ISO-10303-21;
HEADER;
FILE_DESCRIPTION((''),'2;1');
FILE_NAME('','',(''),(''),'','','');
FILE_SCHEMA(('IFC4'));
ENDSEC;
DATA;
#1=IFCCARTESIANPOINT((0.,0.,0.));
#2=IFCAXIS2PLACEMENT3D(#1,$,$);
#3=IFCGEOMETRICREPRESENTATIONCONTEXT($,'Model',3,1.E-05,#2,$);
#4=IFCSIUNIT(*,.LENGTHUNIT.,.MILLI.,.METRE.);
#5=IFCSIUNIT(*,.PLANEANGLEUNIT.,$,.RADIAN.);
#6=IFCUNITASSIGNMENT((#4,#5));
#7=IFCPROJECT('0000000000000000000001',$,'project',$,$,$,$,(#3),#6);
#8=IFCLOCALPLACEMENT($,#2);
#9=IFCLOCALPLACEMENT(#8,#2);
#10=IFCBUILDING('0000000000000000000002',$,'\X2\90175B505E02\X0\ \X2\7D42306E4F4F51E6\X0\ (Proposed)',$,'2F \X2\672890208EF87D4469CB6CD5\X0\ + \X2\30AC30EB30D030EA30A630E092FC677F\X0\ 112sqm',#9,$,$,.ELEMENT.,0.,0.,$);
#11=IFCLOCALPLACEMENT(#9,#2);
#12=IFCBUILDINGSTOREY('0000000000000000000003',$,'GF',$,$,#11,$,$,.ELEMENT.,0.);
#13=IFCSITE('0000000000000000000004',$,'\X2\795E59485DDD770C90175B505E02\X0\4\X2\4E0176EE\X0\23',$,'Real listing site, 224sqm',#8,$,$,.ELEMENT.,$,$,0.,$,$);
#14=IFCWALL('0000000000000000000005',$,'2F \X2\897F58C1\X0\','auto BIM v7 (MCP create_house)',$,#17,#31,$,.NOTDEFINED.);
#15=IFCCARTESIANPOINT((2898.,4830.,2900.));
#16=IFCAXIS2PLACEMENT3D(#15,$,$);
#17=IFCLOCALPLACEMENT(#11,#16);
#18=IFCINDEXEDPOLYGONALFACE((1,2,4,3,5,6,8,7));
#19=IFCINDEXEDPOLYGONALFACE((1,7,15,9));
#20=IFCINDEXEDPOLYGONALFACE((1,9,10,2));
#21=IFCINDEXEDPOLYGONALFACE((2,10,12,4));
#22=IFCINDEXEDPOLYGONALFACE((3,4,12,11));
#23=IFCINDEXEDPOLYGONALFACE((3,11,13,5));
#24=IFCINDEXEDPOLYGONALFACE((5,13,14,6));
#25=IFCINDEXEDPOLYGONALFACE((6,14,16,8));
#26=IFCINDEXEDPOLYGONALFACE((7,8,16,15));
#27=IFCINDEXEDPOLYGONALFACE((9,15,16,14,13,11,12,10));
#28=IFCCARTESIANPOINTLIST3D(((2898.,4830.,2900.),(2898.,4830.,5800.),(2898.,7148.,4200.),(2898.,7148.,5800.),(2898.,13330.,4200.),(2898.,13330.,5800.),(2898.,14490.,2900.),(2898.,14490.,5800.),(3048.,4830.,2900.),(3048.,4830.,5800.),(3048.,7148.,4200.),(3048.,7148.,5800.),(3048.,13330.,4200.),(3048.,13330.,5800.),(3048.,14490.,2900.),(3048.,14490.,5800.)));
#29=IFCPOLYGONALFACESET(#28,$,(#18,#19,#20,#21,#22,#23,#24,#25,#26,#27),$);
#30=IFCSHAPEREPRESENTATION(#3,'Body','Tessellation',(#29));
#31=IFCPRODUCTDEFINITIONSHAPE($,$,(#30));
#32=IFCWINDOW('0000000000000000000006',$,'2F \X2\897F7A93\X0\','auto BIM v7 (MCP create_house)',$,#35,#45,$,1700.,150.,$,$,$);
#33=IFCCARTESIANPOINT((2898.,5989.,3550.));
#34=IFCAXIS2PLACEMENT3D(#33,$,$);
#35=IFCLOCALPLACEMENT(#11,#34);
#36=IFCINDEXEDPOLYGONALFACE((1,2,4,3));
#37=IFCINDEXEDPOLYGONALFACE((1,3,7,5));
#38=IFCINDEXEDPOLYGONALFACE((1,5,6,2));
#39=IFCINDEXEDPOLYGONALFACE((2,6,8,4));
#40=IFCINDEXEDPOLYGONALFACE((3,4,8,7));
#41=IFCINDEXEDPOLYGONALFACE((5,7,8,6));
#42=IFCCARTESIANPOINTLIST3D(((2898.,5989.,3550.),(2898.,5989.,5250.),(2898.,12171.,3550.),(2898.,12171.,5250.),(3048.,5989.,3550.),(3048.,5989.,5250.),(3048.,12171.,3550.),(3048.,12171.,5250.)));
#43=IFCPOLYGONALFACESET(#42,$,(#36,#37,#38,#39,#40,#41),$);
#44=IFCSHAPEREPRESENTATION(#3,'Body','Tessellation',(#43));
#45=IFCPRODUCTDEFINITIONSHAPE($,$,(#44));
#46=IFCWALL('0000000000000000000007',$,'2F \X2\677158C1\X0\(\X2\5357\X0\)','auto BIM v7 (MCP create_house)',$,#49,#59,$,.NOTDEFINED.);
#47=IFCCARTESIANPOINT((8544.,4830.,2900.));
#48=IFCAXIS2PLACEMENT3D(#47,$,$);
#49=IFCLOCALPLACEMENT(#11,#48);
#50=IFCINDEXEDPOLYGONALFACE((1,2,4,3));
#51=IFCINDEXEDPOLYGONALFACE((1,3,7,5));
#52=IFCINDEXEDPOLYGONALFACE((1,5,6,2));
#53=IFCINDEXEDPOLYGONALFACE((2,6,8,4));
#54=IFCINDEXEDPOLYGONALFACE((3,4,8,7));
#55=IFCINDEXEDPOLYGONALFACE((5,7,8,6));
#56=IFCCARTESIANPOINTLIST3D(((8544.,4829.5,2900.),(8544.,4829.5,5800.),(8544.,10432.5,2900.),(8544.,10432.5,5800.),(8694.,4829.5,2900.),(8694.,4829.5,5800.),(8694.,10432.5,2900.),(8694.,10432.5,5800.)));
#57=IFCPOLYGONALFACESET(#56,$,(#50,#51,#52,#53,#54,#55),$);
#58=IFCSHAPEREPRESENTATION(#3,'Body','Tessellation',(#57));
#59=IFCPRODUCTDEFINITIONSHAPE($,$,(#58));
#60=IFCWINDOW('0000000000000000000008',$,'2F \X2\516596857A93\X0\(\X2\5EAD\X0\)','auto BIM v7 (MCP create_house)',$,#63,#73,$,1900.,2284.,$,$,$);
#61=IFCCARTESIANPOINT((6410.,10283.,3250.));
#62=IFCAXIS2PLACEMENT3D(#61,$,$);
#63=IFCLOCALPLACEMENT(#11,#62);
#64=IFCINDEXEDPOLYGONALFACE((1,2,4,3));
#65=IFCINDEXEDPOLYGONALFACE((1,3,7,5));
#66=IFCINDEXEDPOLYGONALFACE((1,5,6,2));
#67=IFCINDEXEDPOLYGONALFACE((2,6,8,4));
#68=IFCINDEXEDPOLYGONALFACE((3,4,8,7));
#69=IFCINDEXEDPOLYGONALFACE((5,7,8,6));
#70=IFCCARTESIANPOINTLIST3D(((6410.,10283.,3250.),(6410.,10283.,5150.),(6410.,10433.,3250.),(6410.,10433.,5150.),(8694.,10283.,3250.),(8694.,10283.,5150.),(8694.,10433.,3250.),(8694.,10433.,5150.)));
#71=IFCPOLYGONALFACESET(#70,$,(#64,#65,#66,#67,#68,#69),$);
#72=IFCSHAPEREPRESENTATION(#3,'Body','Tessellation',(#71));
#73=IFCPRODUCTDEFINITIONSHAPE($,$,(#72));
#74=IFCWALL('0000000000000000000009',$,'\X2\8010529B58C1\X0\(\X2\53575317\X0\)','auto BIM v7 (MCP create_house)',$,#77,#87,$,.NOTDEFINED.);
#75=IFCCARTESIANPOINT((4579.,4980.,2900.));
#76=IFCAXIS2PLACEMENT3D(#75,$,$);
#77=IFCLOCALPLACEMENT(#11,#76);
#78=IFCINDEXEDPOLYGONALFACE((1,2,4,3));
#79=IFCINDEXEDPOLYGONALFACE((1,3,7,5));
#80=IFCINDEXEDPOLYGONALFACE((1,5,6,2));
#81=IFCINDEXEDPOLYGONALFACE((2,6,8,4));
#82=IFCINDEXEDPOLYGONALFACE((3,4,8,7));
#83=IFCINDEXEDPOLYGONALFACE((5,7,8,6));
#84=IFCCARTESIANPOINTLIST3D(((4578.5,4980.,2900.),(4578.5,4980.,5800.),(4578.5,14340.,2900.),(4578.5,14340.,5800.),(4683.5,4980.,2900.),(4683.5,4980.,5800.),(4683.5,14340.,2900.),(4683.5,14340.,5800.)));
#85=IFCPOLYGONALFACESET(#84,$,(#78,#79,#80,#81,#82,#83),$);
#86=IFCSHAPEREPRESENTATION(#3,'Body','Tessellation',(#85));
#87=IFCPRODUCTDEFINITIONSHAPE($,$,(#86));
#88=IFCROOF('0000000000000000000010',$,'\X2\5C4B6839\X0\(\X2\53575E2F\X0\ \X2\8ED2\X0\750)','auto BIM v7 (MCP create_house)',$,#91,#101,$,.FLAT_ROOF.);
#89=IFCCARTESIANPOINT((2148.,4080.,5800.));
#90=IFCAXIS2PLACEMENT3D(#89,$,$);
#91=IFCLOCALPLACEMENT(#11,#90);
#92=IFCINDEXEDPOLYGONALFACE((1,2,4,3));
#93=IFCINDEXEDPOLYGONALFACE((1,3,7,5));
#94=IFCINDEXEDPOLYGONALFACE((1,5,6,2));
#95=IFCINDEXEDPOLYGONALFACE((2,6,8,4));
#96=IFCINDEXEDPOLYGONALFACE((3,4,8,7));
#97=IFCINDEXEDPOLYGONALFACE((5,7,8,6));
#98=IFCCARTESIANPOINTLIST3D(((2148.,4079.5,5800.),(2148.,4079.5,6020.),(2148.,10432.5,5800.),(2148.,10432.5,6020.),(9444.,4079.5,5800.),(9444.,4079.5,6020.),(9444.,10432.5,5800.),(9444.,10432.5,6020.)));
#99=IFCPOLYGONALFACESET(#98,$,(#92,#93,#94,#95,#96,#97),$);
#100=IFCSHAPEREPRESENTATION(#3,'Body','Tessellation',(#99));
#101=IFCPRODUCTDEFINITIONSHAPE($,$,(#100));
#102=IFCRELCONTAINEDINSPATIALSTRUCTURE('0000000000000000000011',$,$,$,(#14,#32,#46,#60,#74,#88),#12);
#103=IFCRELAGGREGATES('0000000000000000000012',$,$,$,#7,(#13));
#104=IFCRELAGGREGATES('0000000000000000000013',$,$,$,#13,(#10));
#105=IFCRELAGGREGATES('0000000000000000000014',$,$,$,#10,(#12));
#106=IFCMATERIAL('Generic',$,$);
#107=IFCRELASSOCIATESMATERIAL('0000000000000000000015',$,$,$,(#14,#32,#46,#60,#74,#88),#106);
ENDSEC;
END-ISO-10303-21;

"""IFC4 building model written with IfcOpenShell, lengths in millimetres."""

from ifc_helpers import new_model, si_unit, frame, frame_2d, origin, place, context, project, spatial, rectangle, extrude, material, element, fill, save


model = new_model("IFC4")

# Units and contexts
model_context = context("Model", 3, precision=1e-05, world=origin())
ifc_project = project(units=[si_unit("LENGTHUNIT", "METRE", prefix="MILLI"), si_unit("PLANEANGLEUNIT", "RADIAN")], contexts=[model_context])

# Site, building, storey
site_placement = place(None, origin())
site = spatial("IfcSite", under=ifc_project, at=site_placement, Name="神奈川県逗子市4丁目23", ObjectType="Real listing site, 224sqm", CompositionType="ELEMENT", RefElevation=0.0)
building_placement = place(site_placement, origin())
building = spatial("IfcBuilding", under=site, at=building_placement, Name="逗子市 終の住処 (Proposed)", ObjectType="2F 木造軸組構法 + ガルバリウム鋼板 112sqm", CompositionType="ELEMENT", ElevationOfRefHeight=0.0, ElevationOfTerrain=0.0)
storey_placement = place(building_placement, origin())
storey = spatial("IfcBuildingStorey", under=building, at=storey_placement, Name="GF", CompositionType="ELEMENT", Elevation=0.0)

# Shared definitions
ifc_material = material(Name="Generic")

# Walls, openings, windows
wall_1_placement = place(storey_placement, frame((2898.0, 4830.0, 2900.0)))
wall_1 = element("IfcWall", 1, at=wall_1_placement, inside=storey, material=ifc_material, Name="2F 西壁", Description="auto BIM v7 (MCP create_house)", PredefinedType="NOTDEFINED", context=model_context, shape_type="SweptSolid", body=[
    extrude(rectangle(XDim=150.0, YDim=9660.0, at=frame_2d((75.0, 4830.0))), frame((2898.0, 4830.0, 2900.0)), (0.0, 0.0, 1.0), 2900.0),
])
opening_1_placement = place(storey_placement, frame((2898.0, 5989.0, 3550.0)))
opening_1 = element("IfcOpeningElement", 2, at=opening_1_placement, cuts=wall_1, PredefinedType="NOTDEFINED", context=model_context, shape_type="SweptSolid", body=[
    extrude(rectangle(XDim=150.0, YDim=6182.0, at=frame_2d((75.0, 3091.0))), frame((2898.0, 5989.0, 3550.0)), (0.0, 0.0, 1.0), 1700.0),
])
window_1_placement = place(storey_placement, frame((2898.0, 5989.0, 3550.0)))
window_1 = element("IfcWindow", 3, at=window_1_placement, inside=storey, material=ifc_material, Name="2F 西窓", Description="auto BIM v7 (MCP create_house)", OverallHeight=1700.0, OverallWidth=150.0, context=model_context, shape_type="SweptSolid", body=[
    extrude(rectangle(XDim=150.0, YDim=6182.0, at=frame_2d((75.0, 3091.0))), frame((2898.0, 5989.0, 3550.0)), (0.0, 0.0, 1.0), 1700.0),
])
fill(opening_1, window_1)
wall_2_placement = place(storey_placement, frame((8544.0, 4830.0, 2900.0)))
wall_2 = element("IfcWall", 4, at=wall_2_placement, inside=storey, material=ifc_material, Name="2F 東壁(南)", Description="auto BIM v7 (MCP create_house)", PredefinedType="NOTDEFINED", context=model_context, shape_type="SweptSolid", body=[
    extrude(rectangle(XDim=150.0, YDim=5603.0, at=frame_2d((75.0, 2801.0))), frame((8544.0, 4830.0, 2900.0)), (0.0, 0.0, 1.0), 2900.0),
])
opening_2_placement = place(storey_placement, frame((6410.0, 10283.0, 3250.0)))
opening_2 = element("IfcOpeningElement", 5, at=opening_2_placement, cuts=wall_2, PredefinedType="NOTDEFINED", context=model_context, shape_type="SweptSolid", body=[
    extrude(rectangle(XDim=2284.0, YDim=150.0, at=frame_2d((1142.0, 75.0))), frame((6410.0, 10283.0, 3250.0)), (0.0, 0.0, 1.0), 1900.0),
])
window_2_placement = place(storey_placement, frame((6410.0, 10283.0, 3250.0)))
window_2 = element("IfcWindow", 6, at=window_2_placement, inside=storey, material=ifc_material, Name="2F 入隅窓(庭)", Description="auto BIM v7 (MCP create_house)", OverallHeight=1900.0, OverallWidth=2284.0, context=model_context, shape_type="SweptSolid", body=[
    extrude(rectangle(XDim=2284.0, YDim=150.0, at=frame_2d((1142.0, 75.0))), frame((6410.0, 10283.0, 3250.0)), (0.0, 0.0, 1.0), 1900.0),
])
fill(opening_2, window_2)

# Wall
wall_3_placement = place(storey_placement, frame((4579.0, 4980.0, 2900.0)))
element("IfcWall", 7, at=wall_3_placement, inside=storey, material=ifc_material, Name="耐力壁(南北)", Description="auto BIM v7 (MCP create_house)", PredefinedType="NOTDEFINED", context=model_context, shape_type="SweptSolid", body=[
    extrude(rectangle(XDim=105.0, YDim=9360.0, at=frame_2d((52.0, 4680.0))), frame((4579.0, 4980.0, 2900.0)), (0.0, 0.0, 1.0), 2900.0),
])

# Roof
for number, where, name in (
    (8, (2148.0, 4080.0, 5800.0), "屋根(南帯 軒750)"),
):
    element("IfcRoof", number, at=place(storey_placement, frame(where)), inside=storey, material=ifc_material, Name=name, Description="auto BIM v7 (MCP create_house)", PredefinedType="FLAT_ROOF", context=model_context, shape_type="SweptSolid", body=[
        extrude(rectangle(XDim=7296.0, YDim=6353.0, at=frame_2d((3648.0, 3176.0))), frame((2148.0, 4080.0, 5800.0)), (0.0, 0.0, 1.0), 220.0),
    ])

save(model, "model.ifc")
